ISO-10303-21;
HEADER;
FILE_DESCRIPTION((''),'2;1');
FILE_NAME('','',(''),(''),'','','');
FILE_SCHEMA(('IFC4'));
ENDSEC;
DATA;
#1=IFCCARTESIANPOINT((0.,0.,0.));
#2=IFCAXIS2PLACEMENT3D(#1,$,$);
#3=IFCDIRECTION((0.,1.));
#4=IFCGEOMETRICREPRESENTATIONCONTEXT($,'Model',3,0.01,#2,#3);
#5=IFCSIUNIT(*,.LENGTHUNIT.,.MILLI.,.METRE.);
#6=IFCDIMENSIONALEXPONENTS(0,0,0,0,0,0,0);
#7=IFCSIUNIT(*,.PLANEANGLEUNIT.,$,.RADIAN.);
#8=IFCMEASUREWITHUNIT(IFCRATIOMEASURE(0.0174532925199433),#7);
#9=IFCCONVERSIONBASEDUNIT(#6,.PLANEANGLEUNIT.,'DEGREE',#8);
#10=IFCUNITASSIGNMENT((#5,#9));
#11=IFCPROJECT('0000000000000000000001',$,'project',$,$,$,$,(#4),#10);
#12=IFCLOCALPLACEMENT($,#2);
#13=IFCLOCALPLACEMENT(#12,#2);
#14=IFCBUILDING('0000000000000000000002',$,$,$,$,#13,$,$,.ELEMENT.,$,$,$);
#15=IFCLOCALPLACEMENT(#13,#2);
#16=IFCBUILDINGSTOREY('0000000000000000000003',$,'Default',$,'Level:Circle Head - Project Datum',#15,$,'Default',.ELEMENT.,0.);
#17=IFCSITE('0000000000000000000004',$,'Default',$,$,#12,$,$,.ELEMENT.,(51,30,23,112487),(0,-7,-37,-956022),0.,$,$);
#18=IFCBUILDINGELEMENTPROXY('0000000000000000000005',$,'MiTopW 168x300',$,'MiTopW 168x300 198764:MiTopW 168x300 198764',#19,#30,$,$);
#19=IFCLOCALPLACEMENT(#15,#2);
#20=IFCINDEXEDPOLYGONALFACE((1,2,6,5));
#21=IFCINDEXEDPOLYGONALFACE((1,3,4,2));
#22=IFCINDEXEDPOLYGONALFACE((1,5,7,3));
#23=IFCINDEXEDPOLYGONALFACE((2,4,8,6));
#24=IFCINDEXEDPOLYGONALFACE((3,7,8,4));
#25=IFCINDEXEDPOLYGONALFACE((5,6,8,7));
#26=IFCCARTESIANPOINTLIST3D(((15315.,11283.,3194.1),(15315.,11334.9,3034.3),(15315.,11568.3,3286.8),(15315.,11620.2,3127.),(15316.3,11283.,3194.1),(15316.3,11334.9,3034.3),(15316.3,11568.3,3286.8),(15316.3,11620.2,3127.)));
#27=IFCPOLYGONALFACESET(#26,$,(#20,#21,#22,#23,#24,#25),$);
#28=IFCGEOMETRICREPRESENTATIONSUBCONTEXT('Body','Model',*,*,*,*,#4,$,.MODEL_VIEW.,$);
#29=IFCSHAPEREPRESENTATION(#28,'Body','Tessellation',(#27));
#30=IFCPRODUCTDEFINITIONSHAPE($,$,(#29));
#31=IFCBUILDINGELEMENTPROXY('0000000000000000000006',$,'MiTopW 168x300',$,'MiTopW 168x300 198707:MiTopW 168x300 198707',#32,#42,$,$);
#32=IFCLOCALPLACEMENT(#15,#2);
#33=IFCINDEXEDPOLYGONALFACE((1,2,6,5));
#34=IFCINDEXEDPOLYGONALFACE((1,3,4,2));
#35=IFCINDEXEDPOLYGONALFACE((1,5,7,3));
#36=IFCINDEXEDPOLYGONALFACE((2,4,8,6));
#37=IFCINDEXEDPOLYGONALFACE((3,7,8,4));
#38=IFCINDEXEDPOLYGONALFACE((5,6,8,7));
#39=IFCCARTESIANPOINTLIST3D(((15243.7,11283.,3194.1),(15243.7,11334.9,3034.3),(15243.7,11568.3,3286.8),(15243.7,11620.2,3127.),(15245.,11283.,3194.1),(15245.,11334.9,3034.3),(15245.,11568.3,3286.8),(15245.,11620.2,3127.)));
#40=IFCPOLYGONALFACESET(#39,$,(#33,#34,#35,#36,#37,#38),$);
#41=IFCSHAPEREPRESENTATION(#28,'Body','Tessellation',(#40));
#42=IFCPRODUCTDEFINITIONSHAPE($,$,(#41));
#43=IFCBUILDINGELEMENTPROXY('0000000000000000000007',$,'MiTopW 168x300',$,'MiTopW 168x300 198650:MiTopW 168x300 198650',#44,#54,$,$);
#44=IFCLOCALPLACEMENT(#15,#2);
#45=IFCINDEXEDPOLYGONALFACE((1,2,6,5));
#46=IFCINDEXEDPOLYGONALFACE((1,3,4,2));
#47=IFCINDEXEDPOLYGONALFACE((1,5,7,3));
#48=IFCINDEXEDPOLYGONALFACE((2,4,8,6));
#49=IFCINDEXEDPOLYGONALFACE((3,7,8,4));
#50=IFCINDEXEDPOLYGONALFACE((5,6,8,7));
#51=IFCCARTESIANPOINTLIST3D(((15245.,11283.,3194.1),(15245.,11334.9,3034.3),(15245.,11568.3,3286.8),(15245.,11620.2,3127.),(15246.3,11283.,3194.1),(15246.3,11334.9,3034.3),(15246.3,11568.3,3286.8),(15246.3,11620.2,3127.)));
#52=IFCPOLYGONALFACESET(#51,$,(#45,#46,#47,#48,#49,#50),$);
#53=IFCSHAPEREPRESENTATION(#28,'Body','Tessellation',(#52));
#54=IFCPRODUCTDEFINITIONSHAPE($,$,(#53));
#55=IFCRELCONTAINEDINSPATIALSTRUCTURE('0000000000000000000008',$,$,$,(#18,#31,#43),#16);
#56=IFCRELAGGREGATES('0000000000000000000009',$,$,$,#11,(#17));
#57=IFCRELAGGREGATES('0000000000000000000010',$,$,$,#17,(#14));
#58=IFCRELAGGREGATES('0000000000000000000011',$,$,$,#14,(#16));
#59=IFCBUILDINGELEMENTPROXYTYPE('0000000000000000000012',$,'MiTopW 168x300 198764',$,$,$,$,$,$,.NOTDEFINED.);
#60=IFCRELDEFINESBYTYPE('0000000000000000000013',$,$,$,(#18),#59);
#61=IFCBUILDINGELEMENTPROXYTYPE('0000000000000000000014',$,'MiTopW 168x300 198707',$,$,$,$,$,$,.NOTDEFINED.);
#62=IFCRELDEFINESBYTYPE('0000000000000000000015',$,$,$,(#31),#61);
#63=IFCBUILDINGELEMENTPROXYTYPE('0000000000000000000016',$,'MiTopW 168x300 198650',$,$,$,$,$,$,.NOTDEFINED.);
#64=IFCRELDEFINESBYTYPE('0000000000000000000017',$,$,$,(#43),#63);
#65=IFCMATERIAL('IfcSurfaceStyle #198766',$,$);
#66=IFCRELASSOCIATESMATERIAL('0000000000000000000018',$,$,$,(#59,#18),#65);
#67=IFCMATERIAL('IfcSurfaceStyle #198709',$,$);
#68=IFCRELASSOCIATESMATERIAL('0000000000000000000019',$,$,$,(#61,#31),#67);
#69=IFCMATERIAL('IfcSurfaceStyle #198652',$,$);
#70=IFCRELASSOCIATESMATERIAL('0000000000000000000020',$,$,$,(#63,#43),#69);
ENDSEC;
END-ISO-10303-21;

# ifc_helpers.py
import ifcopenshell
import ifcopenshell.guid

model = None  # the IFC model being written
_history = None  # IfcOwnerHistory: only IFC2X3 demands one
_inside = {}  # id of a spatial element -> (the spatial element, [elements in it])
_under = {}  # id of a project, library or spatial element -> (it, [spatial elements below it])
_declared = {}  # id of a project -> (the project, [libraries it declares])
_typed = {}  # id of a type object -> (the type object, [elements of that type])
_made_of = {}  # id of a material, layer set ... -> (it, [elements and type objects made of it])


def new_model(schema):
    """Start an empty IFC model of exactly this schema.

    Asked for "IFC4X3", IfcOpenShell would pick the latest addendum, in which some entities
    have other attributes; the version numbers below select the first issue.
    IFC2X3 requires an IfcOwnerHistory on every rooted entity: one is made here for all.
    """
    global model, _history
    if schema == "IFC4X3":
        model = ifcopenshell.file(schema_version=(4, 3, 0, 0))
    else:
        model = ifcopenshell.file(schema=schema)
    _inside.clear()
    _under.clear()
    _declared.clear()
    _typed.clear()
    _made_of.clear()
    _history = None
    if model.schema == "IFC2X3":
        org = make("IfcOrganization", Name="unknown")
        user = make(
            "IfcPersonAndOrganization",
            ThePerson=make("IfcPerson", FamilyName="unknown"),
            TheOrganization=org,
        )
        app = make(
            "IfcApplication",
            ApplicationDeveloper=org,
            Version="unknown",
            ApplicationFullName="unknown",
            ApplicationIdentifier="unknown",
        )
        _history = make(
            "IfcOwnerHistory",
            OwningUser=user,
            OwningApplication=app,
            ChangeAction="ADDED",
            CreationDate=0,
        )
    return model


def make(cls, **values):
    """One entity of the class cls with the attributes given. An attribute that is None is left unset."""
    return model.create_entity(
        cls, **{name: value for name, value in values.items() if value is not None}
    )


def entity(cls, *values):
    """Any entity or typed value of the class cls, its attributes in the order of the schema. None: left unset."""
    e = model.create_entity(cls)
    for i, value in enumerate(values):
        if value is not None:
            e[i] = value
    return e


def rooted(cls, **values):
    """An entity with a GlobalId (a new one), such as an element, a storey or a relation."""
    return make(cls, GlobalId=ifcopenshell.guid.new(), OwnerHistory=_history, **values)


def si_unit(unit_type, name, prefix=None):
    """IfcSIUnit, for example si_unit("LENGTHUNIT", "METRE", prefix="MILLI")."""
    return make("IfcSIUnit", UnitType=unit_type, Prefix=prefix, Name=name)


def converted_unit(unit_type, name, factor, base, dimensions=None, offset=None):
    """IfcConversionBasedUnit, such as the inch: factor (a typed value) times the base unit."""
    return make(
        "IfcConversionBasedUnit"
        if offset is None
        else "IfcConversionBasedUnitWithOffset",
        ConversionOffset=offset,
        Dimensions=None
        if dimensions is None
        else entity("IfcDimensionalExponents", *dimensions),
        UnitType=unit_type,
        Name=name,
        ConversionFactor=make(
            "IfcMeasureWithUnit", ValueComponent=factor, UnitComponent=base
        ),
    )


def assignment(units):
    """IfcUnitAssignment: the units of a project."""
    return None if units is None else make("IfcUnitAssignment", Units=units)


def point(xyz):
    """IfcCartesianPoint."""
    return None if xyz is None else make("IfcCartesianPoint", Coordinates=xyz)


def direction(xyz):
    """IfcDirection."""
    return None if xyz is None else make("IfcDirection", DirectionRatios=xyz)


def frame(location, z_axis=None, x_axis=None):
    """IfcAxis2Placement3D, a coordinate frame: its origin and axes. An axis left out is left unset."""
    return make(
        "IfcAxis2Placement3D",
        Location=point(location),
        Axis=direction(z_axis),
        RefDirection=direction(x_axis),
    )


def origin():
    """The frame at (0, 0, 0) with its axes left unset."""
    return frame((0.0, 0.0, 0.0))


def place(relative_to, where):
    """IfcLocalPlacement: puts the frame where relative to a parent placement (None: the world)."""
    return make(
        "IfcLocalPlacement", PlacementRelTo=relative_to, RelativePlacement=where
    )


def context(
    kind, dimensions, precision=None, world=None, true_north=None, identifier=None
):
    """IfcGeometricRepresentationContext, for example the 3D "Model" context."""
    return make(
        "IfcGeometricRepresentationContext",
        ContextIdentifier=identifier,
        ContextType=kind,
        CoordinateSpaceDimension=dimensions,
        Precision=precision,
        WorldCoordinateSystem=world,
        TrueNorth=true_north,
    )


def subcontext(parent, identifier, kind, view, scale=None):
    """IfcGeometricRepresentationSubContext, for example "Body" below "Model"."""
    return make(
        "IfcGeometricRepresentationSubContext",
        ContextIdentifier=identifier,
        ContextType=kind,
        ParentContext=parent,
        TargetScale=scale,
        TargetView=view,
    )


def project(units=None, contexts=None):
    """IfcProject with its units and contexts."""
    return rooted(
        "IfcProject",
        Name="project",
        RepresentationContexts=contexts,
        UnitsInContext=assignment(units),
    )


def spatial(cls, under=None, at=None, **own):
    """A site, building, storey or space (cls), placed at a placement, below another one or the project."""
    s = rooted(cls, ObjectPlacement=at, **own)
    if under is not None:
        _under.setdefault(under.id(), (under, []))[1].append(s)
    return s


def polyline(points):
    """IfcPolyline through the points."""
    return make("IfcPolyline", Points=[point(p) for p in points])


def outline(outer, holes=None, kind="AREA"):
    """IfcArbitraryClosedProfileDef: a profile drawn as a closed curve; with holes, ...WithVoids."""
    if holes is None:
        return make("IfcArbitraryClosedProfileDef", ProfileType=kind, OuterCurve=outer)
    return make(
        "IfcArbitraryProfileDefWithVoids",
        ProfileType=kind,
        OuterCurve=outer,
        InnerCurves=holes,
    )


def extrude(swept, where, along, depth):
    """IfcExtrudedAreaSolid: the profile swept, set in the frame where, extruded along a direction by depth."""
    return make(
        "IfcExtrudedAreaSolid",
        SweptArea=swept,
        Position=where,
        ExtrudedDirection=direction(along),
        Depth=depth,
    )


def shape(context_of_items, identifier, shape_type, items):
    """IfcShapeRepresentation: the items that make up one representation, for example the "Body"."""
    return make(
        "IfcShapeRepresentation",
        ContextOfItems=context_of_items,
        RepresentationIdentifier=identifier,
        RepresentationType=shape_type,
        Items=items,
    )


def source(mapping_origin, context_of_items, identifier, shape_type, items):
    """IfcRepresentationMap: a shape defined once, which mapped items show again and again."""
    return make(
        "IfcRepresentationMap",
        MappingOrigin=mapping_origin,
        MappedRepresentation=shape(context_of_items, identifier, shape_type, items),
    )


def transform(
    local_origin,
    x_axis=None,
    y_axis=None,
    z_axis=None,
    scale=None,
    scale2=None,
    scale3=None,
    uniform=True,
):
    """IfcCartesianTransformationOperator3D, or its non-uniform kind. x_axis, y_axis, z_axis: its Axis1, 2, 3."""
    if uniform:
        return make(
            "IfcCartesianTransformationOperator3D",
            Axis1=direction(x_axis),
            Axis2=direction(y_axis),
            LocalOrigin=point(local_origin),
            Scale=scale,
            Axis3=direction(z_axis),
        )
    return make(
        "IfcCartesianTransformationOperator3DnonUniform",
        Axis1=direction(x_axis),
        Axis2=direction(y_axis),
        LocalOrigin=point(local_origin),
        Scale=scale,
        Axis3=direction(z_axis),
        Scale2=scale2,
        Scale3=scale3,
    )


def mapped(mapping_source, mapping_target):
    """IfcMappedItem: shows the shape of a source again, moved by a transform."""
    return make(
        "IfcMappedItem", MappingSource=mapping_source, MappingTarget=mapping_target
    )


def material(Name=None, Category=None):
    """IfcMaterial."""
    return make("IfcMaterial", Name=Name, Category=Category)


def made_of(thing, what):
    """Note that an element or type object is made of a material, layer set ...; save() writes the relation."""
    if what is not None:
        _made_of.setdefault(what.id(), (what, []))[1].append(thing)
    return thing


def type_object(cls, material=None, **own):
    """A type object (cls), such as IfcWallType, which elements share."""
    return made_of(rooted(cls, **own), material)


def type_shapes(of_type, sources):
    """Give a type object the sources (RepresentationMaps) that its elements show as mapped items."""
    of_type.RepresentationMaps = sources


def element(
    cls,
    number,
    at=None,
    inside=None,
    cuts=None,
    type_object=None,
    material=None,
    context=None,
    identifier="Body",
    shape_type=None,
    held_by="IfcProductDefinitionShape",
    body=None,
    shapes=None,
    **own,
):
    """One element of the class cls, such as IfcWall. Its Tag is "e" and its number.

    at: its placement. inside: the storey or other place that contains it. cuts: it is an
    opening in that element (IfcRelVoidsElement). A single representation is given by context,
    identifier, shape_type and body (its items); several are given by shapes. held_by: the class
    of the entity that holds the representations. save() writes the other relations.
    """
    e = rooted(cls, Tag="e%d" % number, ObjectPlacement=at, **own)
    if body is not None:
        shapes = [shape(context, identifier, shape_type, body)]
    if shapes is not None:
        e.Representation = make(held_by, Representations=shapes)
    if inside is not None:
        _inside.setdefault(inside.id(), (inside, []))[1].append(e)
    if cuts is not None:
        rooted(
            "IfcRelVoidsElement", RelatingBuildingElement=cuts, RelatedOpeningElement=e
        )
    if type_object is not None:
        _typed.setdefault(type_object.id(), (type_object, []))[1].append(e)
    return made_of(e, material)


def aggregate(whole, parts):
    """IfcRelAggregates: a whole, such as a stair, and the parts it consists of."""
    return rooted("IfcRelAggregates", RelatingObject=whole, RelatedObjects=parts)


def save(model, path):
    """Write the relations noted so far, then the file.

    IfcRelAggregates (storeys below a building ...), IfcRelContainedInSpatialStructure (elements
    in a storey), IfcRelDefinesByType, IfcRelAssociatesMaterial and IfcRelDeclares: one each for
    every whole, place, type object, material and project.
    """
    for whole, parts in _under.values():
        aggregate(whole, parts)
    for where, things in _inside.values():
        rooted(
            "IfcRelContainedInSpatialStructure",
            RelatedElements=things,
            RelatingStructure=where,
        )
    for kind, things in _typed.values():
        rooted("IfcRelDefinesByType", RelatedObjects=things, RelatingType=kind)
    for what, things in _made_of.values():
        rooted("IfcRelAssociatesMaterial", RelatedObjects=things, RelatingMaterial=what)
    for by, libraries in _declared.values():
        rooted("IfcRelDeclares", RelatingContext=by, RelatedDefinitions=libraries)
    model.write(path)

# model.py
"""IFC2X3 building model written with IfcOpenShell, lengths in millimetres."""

from ifc_helpers import new_model, entity, si_unit, converted_unit, direction, frame, origin, place, context, subcontext, project, spatial, polyline, outline, extrude, source, transform, mapped, material, type_object, type_shapes, element, save


model = new_model("IFC2X3")

# Units and contexts
model_context = context("Model", 3, precision=0.01, world=origin(), true_north=direction((0.0, 1.0)))
body_context = subcontext(model_context, "Body", "Model", "MODEL_VIEW")
ifc_project = project(units=[si_unit("LENGTHUNIT", "METRE", prefix="MILLI"), converted_unit("PLANEANGLEUNIT", "DEGREE", entity("IfcRatioMeasure", 0.0174532925199433), si_unit("PLANEANGLEUNIT", "RADIAN"), dimensions=[0, 0, 0, 0, 0, 0, 0])], contexts=[model_context])

# Site, building, storey
site_placement = place(None, origin())
site = spatial("IfcSite", under=ifc_project, at=site_placement, Name="Default", CompositionType="ELEMENT", RefLatitude=(51, 30, 23, 112487), RefLongitude=(0, -7, -37, -956022), RefElevation=0.0)
building_placement = place(site_placement, origin())
building = spatial("IfcBuilding", under=site, at=building_placement, CompositionType="ELEMENT")
storey_placement = place(building_placement, origin())
storey = spatial("IfcBuildingStorey", under=building, at=storey_placement, Name="Default", ObjectType="Level:Circle Head - Project Datum", LongName="Default", CompositionType="ELEMENT", Elevation=0.0)

# Building element proxies
ifc_material_1 = material(Name="IfcSurfaceStyle #198766")
building_element_proxy_type_1 = type_object("IfcBuildingElementProxyType", Name="MiTopW 168x300 198764", PredefinedType="NOTDEFINED", material=ifc_material_1)
shared_shape_1 = source(origin(), body_context, "Body", "SweptSolid", [
    extrude(outline(polyline([(-150.0, -84.0), (150.0, -84.0), (150.0, 84.0), (-150.0, 84.0), (-150.0, -84.0)])), frame((150.0, 84.0, 0.0), z_axis=(0.0, 0.0, 1.0), x_axis=(-1.0, 0.0, 0.0)), (0.0, 0.0, 1.0), 1.3),
])
type_shapes(building_element_proxy_type_1, [shared_shape_1])
proxy_1_placement = place(building_placement, frame((15316.3, 11283.0, 3194.1), z_axis=(-1.0, 0.0, 0.0), x_axis=(0.0, 0.951057, 0.309017)))
element("IfcBuildingElementProxy", 1, at=proxy_1_placement, inside=storey, type_object=building_element_proxy_type_1, material=ifc_material_1, Name="MiTopW 168x300", ObjectType="MiTopW 168x300 198764:MiTopW 168x300 198764", context=body_context, shape_type="MappedRepresentation", body=[
    mapped(shared_shape_1, transform((0.0, 0.0, 0.0), scale=1.0)),
])
ifc_material_2 = material(Name="IfcSurfaceStyle #198709")
building_element_proxy_type_2 = type_object("IfcBuildingElementProxyType", Name="MiTopW 168x300 198707", PredefinedType="NOTDEFINED", material=ifc_material_2)
shared_shape_2 = source(origin(), body_context, "Body", "SweptSolid", [
    extrude(outline(polyline([(-150.0, -84.0), (150.0, -84.0), (150.0, 84.0), (-150.0, 84.0), (-150.0, -84.0)])), frame((150.0, 84.0, 0.0), z_axis=(0.0, 0.0, 1.0), x_axis=(-1.0, 0.0, 0.0)), (0.0, 0.0, 1.0), 1.3),
])
type_shapes(building_element_proxy_type_2, [shared_shape_2])
proxy_2_placement = place(building_placement, frame((15245.0, 11283.0, 3194.1), z_axis=(-1.0, 0.0, 0.0), x_axis=(0.0, 0.951057, 0.309017)))
element("IfcBuildingElementProxy", 2, at=proxy_2_placement, inside=storey, type_object=building_element_proxy_type_2, material=ifc_material_2, Name="MiTopW 168x300", ObjectType="MiTopW 168x300 198707:MiTopW 168x300 198707", context=body_context, shape_type="MappedRepresentation", body=[
    mapped(shared_shape_2, transform((0.0, 0.0, 0.0), scale=1.0)),
])
ifc_material_3 = material(Name="IfcSurfaceStyle #198652")
building_element_proxy_type_3 = type_object("IfcBuildingElementProxyType", Name="MiTopW 168x300 198650", PredefinedType="NOTDEFINED", material=ifc_material_3)
shared_shape_3 = source(origin(), body_context, "Body", "SweptSolid", [
    extrude(outline(polyline([(-150.0, -84.0), (150.0, -84.0), (150.0, 84.0), (-150.0, 84.0), (-150.0, -84.0)])), frame((150.0, 84.0, 0.0), z_axis=(0.0, 0.0, 1.0), x_axis=(-1.0, 0.0, 0.0)), (0.0, 0.0, 1.0), 1.3),
])
type_shapes(building_element_proxy_type_3, [shared_shape_3])
proxy_3_placement = place(building_placement, frame((15246.3, 11283.0, 3194.1), z_axis=(-1.0, 0.0, 0.0), x_axis=(0.0, 0.951057, 0.309017)))
element("IfcBuildingElementProxy", 3, at=proxy_3_placement, inside=storey, type_object=building_element_proxy_type_3, material=ifc_material_3, Name="MiTopW 168x300", ObjectType="MiTopW 168x300 198650:MiTopW 168x300 198650", context=body_context, shape_type="MappedRepresentation", body=[
    mapped(shared_shape_3, transform((0.0, 0.0, 0.0), scale=1.0)),
])

save(model, "model.ifc")
